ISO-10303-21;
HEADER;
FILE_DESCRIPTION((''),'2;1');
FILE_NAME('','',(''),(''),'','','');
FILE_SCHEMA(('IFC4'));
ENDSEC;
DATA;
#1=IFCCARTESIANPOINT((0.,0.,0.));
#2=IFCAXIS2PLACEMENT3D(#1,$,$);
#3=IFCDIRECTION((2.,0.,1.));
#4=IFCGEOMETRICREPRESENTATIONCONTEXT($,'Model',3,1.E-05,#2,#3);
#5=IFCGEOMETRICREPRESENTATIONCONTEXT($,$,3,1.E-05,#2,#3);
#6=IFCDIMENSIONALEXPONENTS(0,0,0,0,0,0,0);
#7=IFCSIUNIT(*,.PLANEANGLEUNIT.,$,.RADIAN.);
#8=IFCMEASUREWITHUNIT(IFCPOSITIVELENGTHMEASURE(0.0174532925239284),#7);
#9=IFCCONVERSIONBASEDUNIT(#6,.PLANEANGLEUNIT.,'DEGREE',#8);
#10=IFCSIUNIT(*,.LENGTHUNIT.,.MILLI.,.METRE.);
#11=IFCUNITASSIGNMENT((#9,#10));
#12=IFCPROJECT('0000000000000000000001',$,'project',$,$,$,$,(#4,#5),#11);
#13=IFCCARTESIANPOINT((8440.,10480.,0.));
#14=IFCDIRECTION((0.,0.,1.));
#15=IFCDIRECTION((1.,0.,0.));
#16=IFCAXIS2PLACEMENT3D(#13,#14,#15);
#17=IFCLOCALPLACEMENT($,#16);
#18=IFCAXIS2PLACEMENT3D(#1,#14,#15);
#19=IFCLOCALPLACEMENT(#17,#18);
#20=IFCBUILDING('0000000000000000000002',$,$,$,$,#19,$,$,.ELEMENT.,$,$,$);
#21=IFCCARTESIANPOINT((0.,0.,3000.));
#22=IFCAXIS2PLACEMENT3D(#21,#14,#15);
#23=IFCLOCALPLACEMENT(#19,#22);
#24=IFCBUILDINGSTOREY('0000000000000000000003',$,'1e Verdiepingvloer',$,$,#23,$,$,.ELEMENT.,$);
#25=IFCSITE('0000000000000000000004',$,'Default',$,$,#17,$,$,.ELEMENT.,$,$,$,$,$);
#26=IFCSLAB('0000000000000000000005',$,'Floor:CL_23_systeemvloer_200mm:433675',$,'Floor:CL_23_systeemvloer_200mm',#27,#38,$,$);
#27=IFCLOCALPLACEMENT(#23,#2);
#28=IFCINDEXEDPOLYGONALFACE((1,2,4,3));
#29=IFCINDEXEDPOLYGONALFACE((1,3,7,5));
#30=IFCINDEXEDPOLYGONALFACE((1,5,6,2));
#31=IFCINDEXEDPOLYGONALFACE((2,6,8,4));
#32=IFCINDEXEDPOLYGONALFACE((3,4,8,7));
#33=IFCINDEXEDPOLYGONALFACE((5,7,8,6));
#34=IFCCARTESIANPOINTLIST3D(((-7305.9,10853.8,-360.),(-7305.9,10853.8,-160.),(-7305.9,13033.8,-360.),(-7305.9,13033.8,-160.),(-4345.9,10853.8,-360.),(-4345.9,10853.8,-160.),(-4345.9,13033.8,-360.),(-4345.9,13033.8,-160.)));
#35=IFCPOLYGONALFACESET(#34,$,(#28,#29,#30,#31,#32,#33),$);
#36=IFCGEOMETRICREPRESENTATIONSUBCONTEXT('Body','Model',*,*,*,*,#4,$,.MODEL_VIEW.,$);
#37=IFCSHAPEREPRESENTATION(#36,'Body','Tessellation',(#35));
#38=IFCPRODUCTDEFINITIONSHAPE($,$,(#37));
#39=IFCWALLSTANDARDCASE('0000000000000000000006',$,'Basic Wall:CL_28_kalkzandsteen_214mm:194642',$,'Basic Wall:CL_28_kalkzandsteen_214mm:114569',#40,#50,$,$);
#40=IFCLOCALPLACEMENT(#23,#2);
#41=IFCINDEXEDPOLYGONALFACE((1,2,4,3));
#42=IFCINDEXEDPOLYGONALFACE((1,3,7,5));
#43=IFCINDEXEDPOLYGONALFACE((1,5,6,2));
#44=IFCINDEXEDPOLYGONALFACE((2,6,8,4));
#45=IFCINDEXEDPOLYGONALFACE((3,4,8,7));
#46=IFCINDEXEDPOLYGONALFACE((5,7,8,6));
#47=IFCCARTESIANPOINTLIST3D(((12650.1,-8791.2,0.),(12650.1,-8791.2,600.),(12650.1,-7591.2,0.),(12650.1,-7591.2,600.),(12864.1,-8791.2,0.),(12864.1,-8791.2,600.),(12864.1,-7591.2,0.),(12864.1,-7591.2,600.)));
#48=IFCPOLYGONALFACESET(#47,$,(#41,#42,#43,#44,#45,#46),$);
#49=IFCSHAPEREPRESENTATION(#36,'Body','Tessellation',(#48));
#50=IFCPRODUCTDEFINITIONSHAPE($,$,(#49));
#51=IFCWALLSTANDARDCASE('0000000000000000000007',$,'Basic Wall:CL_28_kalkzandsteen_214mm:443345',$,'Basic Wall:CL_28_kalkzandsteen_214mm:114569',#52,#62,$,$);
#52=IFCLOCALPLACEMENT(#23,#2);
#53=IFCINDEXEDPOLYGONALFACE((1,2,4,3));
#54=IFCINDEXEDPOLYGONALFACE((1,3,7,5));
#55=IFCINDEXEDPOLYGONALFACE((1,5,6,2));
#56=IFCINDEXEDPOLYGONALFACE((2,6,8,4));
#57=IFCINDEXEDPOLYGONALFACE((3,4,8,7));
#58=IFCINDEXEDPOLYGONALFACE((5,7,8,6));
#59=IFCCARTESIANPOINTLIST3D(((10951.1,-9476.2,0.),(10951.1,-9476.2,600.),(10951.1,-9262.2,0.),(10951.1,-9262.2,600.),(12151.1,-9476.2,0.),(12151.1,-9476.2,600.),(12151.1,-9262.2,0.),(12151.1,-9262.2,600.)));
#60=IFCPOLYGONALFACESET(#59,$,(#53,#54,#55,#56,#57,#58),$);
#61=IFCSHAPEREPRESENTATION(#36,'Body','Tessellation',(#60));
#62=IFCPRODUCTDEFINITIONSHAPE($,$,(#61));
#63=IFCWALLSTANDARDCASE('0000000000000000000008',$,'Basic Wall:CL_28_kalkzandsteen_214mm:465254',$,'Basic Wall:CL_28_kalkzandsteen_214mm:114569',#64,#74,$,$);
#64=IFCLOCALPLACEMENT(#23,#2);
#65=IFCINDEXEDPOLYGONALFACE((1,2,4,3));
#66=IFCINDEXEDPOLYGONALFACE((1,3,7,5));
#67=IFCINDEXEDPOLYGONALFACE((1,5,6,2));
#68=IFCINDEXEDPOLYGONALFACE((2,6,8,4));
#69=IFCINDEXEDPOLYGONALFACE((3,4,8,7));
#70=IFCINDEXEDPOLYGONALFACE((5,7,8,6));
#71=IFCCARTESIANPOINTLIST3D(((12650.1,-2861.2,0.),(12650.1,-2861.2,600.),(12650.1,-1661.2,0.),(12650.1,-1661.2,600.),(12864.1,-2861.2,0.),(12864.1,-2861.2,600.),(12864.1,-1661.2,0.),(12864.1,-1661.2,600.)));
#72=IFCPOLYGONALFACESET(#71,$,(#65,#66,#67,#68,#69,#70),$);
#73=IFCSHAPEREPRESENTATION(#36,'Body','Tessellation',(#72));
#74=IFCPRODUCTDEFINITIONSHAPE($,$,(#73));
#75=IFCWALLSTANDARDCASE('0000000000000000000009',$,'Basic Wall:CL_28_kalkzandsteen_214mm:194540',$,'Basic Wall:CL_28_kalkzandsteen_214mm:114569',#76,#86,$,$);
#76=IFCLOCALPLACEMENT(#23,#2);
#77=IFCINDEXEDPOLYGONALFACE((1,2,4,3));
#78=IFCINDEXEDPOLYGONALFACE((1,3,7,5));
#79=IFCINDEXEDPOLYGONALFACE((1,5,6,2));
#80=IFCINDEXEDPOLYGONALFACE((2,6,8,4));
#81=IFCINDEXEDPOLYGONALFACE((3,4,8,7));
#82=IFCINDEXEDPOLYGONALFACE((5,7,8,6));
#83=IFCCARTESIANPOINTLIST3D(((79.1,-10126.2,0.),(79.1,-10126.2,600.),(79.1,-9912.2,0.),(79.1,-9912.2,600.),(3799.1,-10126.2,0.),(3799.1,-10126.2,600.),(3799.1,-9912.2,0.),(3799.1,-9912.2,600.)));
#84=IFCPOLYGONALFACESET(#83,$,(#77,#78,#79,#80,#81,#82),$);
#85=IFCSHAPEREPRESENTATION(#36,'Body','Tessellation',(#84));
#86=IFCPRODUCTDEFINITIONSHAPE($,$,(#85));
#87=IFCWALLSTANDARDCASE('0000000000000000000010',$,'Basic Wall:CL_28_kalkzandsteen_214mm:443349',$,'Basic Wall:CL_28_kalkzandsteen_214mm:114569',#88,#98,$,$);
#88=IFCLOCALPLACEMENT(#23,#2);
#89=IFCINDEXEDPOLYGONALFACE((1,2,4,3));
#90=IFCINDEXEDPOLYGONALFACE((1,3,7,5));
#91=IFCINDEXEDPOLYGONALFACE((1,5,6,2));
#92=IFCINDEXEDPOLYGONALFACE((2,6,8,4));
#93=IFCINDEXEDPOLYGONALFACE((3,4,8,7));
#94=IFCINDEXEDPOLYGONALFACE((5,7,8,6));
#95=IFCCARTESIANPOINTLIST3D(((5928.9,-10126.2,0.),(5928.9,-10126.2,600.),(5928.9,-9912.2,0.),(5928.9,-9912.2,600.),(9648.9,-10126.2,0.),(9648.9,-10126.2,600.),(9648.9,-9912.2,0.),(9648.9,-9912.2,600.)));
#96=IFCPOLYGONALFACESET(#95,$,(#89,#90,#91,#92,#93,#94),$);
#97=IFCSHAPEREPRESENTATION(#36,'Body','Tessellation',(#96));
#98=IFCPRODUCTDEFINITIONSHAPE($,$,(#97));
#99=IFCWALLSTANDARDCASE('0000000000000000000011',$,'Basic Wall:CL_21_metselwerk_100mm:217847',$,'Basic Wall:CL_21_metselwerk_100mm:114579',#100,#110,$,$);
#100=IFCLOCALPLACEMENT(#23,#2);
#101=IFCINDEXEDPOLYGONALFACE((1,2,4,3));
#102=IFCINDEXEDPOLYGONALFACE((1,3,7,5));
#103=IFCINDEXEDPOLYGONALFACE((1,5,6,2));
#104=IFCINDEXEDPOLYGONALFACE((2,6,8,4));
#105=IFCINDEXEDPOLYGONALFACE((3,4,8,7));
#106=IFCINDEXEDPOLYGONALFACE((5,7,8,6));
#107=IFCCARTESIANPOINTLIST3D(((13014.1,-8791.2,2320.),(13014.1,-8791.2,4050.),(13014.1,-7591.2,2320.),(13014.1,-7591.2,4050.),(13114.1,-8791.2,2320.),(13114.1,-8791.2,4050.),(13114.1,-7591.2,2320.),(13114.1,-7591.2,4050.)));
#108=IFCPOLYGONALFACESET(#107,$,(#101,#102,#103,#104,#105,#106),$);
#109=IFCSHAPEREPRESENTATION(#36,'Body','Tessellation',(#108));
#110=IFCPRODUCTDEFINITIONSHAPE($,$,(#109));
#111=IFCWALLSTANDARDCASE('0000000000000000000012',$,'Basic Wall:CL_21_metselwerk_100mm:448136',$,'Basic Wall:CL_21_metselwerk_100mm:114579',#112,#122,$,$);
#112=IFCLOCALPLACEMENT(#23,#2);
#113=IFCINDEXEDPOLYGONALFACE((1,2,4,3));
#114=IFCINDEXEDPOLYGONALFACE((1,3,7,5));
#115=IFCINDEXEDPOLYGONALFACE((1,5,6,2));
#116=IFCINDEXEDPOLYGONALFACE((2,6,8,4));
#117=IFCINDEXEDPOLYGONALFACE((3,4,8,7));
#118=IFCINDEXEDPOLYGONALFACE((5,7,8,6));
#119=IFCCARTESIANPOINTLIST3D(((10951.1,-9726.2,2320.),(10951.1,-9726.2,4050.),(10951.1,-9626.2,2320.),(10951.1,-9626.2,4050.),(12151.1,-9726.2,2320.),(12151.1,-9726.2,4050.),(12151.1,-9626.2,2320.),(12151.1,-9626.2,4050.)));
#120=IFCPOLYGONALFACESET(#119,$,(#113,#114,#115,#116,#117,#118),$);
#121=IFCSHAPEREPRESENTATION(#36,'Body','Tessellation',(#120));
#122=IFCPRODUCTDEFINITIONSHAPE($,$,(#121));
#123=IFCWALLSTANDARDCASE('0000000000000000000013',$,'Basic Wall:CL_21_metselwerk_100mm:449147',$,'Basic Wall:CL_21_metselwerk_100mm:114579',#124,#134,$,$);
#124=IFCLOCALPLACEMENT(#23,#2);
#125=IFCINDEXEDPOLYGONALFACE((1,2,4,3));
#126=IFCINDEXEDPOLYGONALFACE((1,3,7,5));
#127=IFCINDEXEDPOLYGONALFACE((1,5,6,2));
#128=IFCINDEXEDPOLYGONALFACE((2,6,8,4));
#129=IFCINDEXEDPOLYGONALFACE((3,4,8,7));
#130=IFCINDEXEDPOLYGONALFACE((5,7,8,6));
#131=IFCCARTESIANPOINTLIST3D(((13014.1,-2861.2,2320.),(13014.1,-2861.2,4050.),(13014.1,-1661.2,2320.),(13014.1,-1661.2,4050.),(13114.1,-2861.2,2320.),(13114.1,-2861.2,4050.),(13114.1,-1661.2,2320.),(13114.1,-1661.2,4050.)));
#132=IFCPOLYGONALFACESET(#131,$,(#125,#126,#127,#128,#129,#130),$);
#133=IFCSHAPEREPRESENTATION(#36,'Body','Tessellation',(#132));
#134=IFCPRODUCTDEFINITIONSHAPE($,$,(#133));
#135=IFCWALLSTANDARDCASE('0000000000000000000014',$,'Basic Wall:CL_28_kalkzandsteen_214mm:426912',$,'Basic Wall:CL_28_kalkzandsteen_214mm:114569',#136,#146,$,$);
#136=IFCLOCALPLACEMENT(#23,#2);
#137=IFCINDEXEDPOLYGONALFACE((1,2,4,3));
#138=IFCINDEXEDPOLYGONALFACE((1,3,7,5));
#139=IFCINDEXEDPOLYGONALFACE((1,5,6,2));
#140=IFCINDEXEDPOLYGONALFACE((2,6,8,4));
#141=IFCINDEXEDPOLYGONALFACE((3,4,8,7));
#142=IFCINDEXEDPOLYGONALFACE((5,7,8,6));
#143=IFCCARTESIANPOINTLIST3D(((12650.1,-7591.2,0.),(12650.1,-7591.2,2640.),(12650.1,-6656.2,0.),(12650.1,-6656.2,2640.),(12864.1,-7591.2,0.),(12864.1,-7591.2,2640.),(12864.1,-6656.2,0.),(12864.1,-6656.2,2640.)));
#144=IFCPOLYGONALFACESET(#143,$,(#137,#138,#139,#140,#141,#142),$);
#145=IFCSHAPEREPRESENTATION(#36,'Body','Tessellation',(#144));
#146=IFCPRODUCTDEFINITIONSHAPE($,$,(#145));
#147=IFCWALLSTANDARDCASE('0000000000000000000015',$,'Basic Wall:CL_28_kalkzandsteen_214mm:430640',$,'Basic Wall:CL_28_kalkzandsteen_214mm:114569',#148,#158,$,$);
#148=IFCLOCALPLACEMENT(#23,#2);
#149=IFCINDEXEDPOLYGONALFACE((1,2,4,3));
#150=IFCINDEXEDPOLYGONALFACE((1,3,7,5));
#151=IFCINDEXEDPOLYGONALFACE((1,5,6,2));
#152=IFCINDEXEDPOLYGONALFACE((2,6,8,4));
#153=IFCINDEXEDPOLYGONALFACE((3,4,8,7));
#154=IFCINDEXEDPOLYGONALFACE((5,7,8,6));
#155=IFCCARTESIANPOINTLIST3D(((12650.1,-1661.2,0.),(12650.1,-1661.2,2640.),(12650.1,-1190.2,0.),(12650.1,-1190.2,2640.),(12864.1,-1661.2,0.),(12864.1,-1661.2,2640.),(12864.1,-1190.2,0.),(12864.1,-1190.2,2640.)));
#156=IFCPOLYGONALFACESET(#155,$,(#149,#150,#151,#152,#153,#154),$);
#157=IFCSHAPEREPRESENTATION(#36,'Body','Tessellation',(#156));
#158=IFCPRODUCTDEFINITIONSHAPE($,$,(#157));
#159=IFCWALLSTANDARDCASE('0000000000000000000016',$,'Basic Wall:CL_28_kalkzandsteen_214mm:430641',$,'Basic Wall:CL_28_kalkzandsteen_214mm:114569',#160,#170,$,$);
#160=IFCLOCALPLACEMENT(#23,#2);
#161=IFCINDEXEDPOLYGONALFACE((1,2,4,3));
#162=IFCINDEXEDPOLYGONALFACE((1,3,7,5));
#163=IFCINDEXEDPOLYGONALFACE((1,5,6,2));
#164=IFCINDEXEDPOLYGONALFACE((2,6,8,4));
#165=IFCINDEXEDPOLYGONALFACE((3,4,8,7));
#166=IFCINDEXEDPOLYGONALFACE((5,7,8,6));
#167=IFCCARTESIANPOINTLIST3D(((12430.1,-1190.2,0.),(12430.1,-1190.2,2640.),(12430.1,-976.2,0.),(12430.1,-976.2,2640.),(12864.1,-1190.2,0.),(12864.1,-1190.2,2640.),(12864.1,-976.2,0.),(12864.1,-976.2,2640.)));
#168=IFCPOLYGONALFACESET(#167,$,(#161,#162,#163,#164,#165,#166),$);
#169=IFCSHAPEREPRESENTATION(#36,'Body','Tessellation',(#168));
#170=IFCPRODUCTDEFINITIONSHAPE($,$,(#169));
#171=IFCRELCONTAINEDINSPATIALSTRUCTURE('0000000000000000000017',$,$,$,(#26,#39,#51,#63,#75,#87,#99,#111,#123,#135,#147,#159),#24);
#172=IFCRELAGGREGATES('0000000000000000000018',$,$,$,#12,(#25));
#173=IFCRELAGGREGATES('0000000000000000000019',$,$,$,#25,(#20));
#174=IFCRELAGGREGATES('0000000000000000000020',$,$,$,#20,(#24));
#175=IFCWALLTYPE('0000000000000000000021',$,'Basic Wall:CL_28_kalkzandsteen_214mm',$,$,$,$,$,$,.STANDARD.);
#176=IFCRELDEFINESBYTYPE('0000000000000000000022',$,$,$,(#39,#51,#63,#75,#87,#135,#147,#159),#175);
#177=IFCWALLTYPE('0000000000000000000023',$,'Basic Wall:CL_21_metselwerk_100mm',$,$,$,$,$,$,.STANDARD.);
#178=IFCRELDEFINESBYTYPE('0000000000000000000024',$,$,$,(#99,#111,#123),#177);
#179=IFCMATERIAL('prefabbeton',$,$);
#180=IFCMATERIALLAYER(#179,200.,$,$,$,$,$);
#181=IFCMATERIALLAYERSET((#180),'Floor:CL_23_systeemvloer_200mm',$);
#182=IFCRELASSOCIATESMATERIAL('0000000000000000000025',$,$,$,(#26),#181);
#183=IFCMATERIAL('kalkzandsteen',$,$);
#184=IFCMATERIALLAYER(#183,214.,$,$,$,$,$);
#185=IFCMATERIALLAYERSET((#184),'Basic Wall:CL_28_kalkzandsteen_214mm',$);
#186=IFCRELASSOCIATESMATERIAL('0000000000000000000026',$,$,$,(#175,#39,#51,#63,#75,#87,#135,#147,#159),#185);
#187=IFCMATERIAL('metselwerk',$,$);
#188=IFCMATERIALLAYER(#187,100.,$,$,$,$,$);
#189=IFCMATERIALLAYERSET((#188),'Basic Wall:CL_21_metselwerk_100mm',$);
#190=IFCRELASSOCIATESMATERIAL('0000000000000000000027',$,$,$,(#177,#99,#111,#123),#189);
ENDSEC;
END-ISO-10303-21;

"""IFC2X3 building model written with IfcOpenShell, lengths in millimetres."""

from ifc_helpers import new_model, entity, si_unit, converted_unit, direction, frame, frame_2d, origin, origin_with_axes, place, context, subcontext, project, spatial, rectangle, extrude, source, transform, mapped, material, layer, layer_set, layer_usage, type_object, element, save


model = new_model("IFC2X3")

# Units and contexts
model_context = context("Model", 3, precision=1e-05, world=origin(), true_north=direction((2.0, 0.0, 1.0)))
context_of_model = context(None, 3, precision=1e-05, world=origin(), true_north=direction((2.0, 0.0, 1.0)))
body_context = subcontext(model_context, "Body", "Model", "MODEL_VIEW")
ifc_project = project(units=[converted_unit("PLANEANGLEUNIT", "DEGREE", entity("IfcPositiveLengthMeasure", 0.0174532925239284), si_unit("PLANEANGLEUNIT", "RADIAN"), dimensions=[0, 0, 0, 0, 0, 0, 0]), si_unit("LENGTHUNIT", "METRE", prefix="MILLI")], contexts=[model_context, context_of_model])

# Site, building, storey
site_placement = place(None, frame((8440.0, 10480.0, 0.0), z_axis=(0.0, 0.0, 1.0), x_axis=(1.0, 0.0, 0.0)))
site = spatial("IfcSite", under=ifc_project, at=site_placement, Name="Default", CompositionType="ELEMENT")
building_placement = place(site_placement, origin_with_axes())
building = spatial("IfcBuilding", under=site, at=building_placement, CompositionType="ELEMENT")
storey_placement = place(building_placement, frame((0.0, 0.0, 3000.0), z_axis=(0.0, 0.0, 1.0), x_axis=(1.0, 0.0, 0.0)))
storey = spatial("IfcBuildingStorey", under=building, at=storey_placement, Name="1e Verdiepingvloer", CompositionType="ELEMENT")

# Slab
ifc_material_1 = material(Name="prefabbeton")
ifc_layer_1 = layer(ifc_material_1, 200.0)
ifc_layer_set_1 = layer_set([ifc_layer_1], Name="Floor:CL_23_systeemvloer_200mm")
ifc_layer_usage_1 = layer_usage(ifc_layer_set_1, "AXIS3", "POSITIVE", 0.0)
slab_1_placement = place(storey_placement, origin_with_axes())
element("IfcSlab", 1, at=slab_1_placement, inside=storey, material=ifc_layer_usage_1, Name="Floor:CL_23_systeemvloer_200mm:433675", ObjectType="Floor:CL_23_systeemvloer_200mm", context=body_context, shape_type="SweptSolid", body=[
    extrude(rectangle(XDim=2180.0, YDim=2960.0, at=frame_2d((0.0, 0.0), x_axis=(1.0, 0.0))), frame((-5825.9, 11943.8, -160.0), z_axis=(0.0, 0.0, -1.0), x_axis=(0.0, 1.0, 0.0)), (0.0, 0.0, 1.0), 200.0),
])

# Walls
ifc_material_2 = material(Name="kalkzandsteen")
ifc_layer_2 = layer(ifc_material_2, 214.0)
ifc_layer_set_2 = layer_set([ifc_layer_2], Name="Basic Wall:CL_28_kalkzandsteen_214mm")
ifc_layer_usage_2 = layer_usage(ifc_layer_set_2, "AXIS2", "NEGATIVE", 107.0)
wall_type_1 = type_object("IfcWallType", Name="Basic Wall:CL_28_kalkzandsteen_214mm", PredefinedType="STANDARD", material=ifc_layer_set_2)
shared_shape_1 = source(origin(), body_context, "Body", "SweptSolid", [
    extrude(rectangle(XDim=1200.0, YDim=214.0, at=frame_2d((600.0, 0.0), x_axis=(-1.0, 0.0))), origin(), (0.0, 0.0, 1.0), 600.0),
])
wall_1_placement = place(storey_placement, frame((12757.1, -8791.2, 0.0), z_axis=(0.0, 0.0, 1.0), x_axis=(0.0, 1.0, 0.0)))
element("IfcWallStandardCase", 2, at=wall_1_placement, inside=storey, type_object=wall_type_1, material=ifc_layer_usage_2, Name="Basic Wall:CL_28_kalkzandsteen_214mm:194642", ObjectType="Basic Wall:CL_28_kalkzandsteen_214mm:114569", context=body_context, shape_type="MappedRepresentation", body=[
    mapped(shared_shape_1, transform((0.0, 0.0, 0.0))),
])
ifc_layer_usage_3 = layer_usage(ifc_layer_set_2, "AXIS2", "POSITIVE", -107.0)
wall_2_placement = place(storey_placement, frame((12151.1, -9369.2, 0.0), z_axis=(0.0, 0.0, 1.0), x_axis=(-1.0, 0.0, 0.0)))
element("IfcWallStandardCase", 3, at=wall_2_placement, inside=storey, type_object=wall_type_1, material=ifc_layer_usage_3, Name="Basic Wall:CL_28_kalkzandsteen_214mm:443345", ObjectType="Basic Wall:CL_28_kalkzandsteen_214mm:114569", context=body_context, shape_type="MappedRepresentation", body=[
    mapped(shared_shape_1, transform((0.0, 0.0, 0.0))),
])
ifc_layer_usage_4 = layer_usage(ifc_layer_set_2, "AXIS2", "NEGATIVE", 107.0)
wall_3_placement = place(storey_placement, frame((12757.1, -2861.2, 0.0), z_axis=(0.0, 0.0, 1.0), x_axis=(0.0, 1.0, 0.0)))
element("IfcWallStandardCase", 4, at=wall_3_placement, inside=storey, type_object=wall_type_1, material=ifc_layer_usage_4, Name="Basic Wall:CL_28_kalkzandsteen_214mm:465254", ObjectType="Basic Wall:CL_28_kalkzandsteen_214mm:114569", context=body_context, shape_type="MappedRepresentation", body=[
    mapped(shared_shape_1, transform((0.0, 0.0, 0.0))),
])
ifc_layer_usage_5 = layer_usage(ifc_layer_set_2, "AXIS2", "NEGATIVE", 107.0)
shared_shape_2 = source(origin(), body_context, "Body", "SweptSolid", [
    extrude(rectangle(XDim=3720.0, YDim=214.0, at=frame_2d((1860.0, 0.0), x_axis=(-1.0, 0.0))), origin(), (0.0, 0.0, 1.0), 600.0),
])
wall_4_placement = place(storey_placement, frame((79.1, -10019.2, 0.0), z_axis=(0.0, 0.0, 1.0), x_axis=(1.0, 0.0, 0.0)))
element("IfcWallStandardCase", 5, at=wall_4_placement, inside=storey, type_object=wall_type_1, material=ifc_layer_usage_5, Name="Basic Wall:CL_28_kalkzandsteen_214mm:194540", ObjectType="Basic Wall:CL_28_kalkzandsteen_214mm:114569", context=body_context, shape_type="MappedRepresentation", body=[
    mapped(shared_shape_2, transform((0.0, 0.0, 0.0))),
])
ifc_layer_usage_6 = layer_usage(ifc_layer_set_2, "AXIS2", "POSITIVE", -107.0)
wall_5_placement = place(storey_placement, frame((9648.9, -10019.2, 0.0), z_axis=(0.0, 0.0, 1.0), x_axis=(-1.0, 0.0, 0.0)))
element("IfcWallStandardCase", 6, at=wall_5_placement, inside=storey, type_object=wall_type_1, material=ifc_layer_usage_6, Name="Basic Wall:CL_28_kalkzandsteen_214mm:443349", ObjectType="Basic Wall:CL_28_kalkzandsteen_214mm:114569", context=body_context, shape_type="MappedRepresentation", body=[
    mapped(shared_shape_2, transform((0.0, 0.0, 0.0))),
])
ifc_material_3 = material(Name="metselwerk")
ifc_layer_3 = layer(ifc_material_3, 100.0)
ifc_layer_set_3 = layer_set([ifc_layer_3], Name="Basic Wall:CL_21_metselwerk_100mm")
ifc_layer_usage_7 = layer_usage(ifc_layer_set_3, "AXIS2", "NEGATIVE", 50.0)
wall_type_2 = type_object("IfcWallType", Name="Basic Wall:CL_21_metselwerk_100mm", PredefinedType="STANDARD", material=ifc_layer_set_3)
shared_shape_3 = source(origin(), body_context, "Body", "SweptSolid", [
    extrude(rectangle(XDim=1200.0, YDim=100.0, at=frame_2d((600.0, 0.0), x_axis=(-1.0, 0.0))), origin(), (0.0, 0.0, 1.0), 1730.0),
])
wall_6_placement = place(storey_placement, frame((13064.1, -8791.2, 2320.0), z_axis=(0.0, 0.0, 1.0), x_axis=(0.0, 1.0, 0.0)))
element("IfcWallStandardCase", 7, at=wall_6_placement, inside=storey, type_object=wall_type_2, material=ifc_layer_usage_7, Name="Basic Wall:CL_21_metselwerk_100mm:217847", ObjectType="Basic Wall:CL_21_metselwerk_100mm:114579", context=body_context, shape_type="MappedRepresentation", body=[
    mapped(shared_shape_3, transform((0.0, 0.0, 0.0))),
])
ifc_layer_usage_8 = layer_usage(ifc_layer_set_3, "AXIS2", "NEGATIVE", 50.0)
wall_7_placement = place(storey_placement, frame((10951.1, -9676.2, 2320.0), z_axis=(0.0, 0.0, 1.0), x_axis=(1.0, 0.0, 0.0)))
element("IfcWallStandardCase", 8, at=wall_7_placement, inside=storey, type_object=wall_type_2, material=ifc_layer_usage_8, Name="Basic Wall:CL_21_metselwerk_100mm:448136", ObjectType="Basic Wall:CL_21_metselwerk_100mm:114579", context=body_context, shape_type="MappedRepresentation", body=[
    mapped(shared_shape_3, transform((0.0, 0.0, 0.0))),
])
ifc_layer_usage_9 = layer_usage(ifc_layer_set_3, "AXIS2", "NEGATIVE", 50.0)
wall_8_placement = place(storey_placement, frame((13064.1, -2861.2, 2320.0), z_axis=(0.0, 0.0, 1.0), x_axis=(0.0, 1.0, 0.0)))
element("IfcWallStandardCase", 9, at=wall_8_placement, inside=storey, type_object=wall_type_2, material=ifc_layer_usage_9, Name="Basic Wall:CL_21_metselwerk_100mm:449147", ObjectType="Basic Wall:CL_21_metselwerk_100mm:114579", context=body_context, shape_type="MappedRepresentation", body=[
    mapped(shared_shape_3, transform((0.0, 0.0, 0.0))),
])
ifc_layer_usage_10 = layer_usage(ifc_layer_set_2, "AXIS2", "NEGATIVE", 107.0)
shared_shape_4 = source(origin(), body_context, "Body", "SweptSolid", [
    extrude(rectangle(XDim=935.0, YDim=214.0, at=frame_2d((467.5, 0.0), x_axis=(-1.0, 0.0))), origin(), (0.0, 0.0, 1.0), 2640.0),
])
wall_9_placement = place(storey_placement, frame((12757.1, -7591.2, 0.0), z_axis=(0.0, 0.0, 1.0), x_axis=(0.0, 1.0, 0.0)))
element("IfcWallStandardCase", 10, at=wall_9_placement, inside=storey, type_object=wall_type_1, material=ifc_layer_usage_10, Name="Basic Wall:CL_28_kalkzandsteen_214mm:426912", ObjectType="Basic Wall:CL_28_kalkzandsteen_214mm:114569", context=body_context, shape_type="MappedRepresentation", body=[
    mapped(shared_shape_4, transform((0.0, 0.0, 0.0))),
])
ifc_layer_usage_11 = layer_usage(ifc_layer_set_2, "AXIS2", "NEGATIVE", 107.0)
shared_shape_5 = source(origin(), body_context, "Body", "SweptSolid", [
    extrude(rectangle(XDim=471.0, YDim=214.0, at=frame_2d((235.5, 0.0), x_axis=(-1.0, 0.0))), origin(), (0.0, 0.0, 1.0), 2640.0),
])
wall_10_placement = place(storey_placement, frame((12757.1, -1661.2, 0.0), z_axis=(0.0, 0.0, 1.0), x_axis=(0.0, 1.0, 0.0)))
element("IfcWallStandardCase", 11, at=wall_10_placement, inside=storey, type_object=wall_type_1, material=ifc_layer_usage_11, Name="Basic Wall:CL_28_kalkzandsteen_214mm:430640", ObjectType="Basic Wall:CL_28_kalkzandsteen_214mm:114569", context=body_context, shape_type="MappedRepresentation", body=[
    mapped(shared_shape_5, transform((0.0, 0.0, 0.0))),
])
ifc_layer_usage_12 = layer_usage(ifc_layer_set_2, "AXIS2", "NEGATIVE", 107.0)
shared_shape_6 = source(origin(), body_context, "Body", "SweptSolid", [
    extrude(rectangle(XDim=434.0, YDim=214.0, at=frame_2d((217.0, 0.0), x_axis=(-1.0, 0.0))), origin(), (0.0, 0.0, 1.0), 2640.0),
])
wall_11_placement = place(storey_placement, frame((12864.1, -1083.2, 0.0), z_axis=(0.0, 0.0, 1.0), x_axis=(-1.0, 0.0, 0.0)))
element("IfcWallStandardCase", 12, at=wall_11_placement, inside=storey, type_object=wall_type_1, material=ifc_layer_usage_12, Name="Basic Wall:CL_28_kalkzandsteen_214mm:430641", ObjectType="Basic Wall:CL_28_kalkzandsteen_214mm:114569", context=body_context, shape_type="MappedRepresentation", body=[
    mapped(shared_shape_6, transform((0.0, 0.0, 0.0))),
])

save(model, "model.ifc")
